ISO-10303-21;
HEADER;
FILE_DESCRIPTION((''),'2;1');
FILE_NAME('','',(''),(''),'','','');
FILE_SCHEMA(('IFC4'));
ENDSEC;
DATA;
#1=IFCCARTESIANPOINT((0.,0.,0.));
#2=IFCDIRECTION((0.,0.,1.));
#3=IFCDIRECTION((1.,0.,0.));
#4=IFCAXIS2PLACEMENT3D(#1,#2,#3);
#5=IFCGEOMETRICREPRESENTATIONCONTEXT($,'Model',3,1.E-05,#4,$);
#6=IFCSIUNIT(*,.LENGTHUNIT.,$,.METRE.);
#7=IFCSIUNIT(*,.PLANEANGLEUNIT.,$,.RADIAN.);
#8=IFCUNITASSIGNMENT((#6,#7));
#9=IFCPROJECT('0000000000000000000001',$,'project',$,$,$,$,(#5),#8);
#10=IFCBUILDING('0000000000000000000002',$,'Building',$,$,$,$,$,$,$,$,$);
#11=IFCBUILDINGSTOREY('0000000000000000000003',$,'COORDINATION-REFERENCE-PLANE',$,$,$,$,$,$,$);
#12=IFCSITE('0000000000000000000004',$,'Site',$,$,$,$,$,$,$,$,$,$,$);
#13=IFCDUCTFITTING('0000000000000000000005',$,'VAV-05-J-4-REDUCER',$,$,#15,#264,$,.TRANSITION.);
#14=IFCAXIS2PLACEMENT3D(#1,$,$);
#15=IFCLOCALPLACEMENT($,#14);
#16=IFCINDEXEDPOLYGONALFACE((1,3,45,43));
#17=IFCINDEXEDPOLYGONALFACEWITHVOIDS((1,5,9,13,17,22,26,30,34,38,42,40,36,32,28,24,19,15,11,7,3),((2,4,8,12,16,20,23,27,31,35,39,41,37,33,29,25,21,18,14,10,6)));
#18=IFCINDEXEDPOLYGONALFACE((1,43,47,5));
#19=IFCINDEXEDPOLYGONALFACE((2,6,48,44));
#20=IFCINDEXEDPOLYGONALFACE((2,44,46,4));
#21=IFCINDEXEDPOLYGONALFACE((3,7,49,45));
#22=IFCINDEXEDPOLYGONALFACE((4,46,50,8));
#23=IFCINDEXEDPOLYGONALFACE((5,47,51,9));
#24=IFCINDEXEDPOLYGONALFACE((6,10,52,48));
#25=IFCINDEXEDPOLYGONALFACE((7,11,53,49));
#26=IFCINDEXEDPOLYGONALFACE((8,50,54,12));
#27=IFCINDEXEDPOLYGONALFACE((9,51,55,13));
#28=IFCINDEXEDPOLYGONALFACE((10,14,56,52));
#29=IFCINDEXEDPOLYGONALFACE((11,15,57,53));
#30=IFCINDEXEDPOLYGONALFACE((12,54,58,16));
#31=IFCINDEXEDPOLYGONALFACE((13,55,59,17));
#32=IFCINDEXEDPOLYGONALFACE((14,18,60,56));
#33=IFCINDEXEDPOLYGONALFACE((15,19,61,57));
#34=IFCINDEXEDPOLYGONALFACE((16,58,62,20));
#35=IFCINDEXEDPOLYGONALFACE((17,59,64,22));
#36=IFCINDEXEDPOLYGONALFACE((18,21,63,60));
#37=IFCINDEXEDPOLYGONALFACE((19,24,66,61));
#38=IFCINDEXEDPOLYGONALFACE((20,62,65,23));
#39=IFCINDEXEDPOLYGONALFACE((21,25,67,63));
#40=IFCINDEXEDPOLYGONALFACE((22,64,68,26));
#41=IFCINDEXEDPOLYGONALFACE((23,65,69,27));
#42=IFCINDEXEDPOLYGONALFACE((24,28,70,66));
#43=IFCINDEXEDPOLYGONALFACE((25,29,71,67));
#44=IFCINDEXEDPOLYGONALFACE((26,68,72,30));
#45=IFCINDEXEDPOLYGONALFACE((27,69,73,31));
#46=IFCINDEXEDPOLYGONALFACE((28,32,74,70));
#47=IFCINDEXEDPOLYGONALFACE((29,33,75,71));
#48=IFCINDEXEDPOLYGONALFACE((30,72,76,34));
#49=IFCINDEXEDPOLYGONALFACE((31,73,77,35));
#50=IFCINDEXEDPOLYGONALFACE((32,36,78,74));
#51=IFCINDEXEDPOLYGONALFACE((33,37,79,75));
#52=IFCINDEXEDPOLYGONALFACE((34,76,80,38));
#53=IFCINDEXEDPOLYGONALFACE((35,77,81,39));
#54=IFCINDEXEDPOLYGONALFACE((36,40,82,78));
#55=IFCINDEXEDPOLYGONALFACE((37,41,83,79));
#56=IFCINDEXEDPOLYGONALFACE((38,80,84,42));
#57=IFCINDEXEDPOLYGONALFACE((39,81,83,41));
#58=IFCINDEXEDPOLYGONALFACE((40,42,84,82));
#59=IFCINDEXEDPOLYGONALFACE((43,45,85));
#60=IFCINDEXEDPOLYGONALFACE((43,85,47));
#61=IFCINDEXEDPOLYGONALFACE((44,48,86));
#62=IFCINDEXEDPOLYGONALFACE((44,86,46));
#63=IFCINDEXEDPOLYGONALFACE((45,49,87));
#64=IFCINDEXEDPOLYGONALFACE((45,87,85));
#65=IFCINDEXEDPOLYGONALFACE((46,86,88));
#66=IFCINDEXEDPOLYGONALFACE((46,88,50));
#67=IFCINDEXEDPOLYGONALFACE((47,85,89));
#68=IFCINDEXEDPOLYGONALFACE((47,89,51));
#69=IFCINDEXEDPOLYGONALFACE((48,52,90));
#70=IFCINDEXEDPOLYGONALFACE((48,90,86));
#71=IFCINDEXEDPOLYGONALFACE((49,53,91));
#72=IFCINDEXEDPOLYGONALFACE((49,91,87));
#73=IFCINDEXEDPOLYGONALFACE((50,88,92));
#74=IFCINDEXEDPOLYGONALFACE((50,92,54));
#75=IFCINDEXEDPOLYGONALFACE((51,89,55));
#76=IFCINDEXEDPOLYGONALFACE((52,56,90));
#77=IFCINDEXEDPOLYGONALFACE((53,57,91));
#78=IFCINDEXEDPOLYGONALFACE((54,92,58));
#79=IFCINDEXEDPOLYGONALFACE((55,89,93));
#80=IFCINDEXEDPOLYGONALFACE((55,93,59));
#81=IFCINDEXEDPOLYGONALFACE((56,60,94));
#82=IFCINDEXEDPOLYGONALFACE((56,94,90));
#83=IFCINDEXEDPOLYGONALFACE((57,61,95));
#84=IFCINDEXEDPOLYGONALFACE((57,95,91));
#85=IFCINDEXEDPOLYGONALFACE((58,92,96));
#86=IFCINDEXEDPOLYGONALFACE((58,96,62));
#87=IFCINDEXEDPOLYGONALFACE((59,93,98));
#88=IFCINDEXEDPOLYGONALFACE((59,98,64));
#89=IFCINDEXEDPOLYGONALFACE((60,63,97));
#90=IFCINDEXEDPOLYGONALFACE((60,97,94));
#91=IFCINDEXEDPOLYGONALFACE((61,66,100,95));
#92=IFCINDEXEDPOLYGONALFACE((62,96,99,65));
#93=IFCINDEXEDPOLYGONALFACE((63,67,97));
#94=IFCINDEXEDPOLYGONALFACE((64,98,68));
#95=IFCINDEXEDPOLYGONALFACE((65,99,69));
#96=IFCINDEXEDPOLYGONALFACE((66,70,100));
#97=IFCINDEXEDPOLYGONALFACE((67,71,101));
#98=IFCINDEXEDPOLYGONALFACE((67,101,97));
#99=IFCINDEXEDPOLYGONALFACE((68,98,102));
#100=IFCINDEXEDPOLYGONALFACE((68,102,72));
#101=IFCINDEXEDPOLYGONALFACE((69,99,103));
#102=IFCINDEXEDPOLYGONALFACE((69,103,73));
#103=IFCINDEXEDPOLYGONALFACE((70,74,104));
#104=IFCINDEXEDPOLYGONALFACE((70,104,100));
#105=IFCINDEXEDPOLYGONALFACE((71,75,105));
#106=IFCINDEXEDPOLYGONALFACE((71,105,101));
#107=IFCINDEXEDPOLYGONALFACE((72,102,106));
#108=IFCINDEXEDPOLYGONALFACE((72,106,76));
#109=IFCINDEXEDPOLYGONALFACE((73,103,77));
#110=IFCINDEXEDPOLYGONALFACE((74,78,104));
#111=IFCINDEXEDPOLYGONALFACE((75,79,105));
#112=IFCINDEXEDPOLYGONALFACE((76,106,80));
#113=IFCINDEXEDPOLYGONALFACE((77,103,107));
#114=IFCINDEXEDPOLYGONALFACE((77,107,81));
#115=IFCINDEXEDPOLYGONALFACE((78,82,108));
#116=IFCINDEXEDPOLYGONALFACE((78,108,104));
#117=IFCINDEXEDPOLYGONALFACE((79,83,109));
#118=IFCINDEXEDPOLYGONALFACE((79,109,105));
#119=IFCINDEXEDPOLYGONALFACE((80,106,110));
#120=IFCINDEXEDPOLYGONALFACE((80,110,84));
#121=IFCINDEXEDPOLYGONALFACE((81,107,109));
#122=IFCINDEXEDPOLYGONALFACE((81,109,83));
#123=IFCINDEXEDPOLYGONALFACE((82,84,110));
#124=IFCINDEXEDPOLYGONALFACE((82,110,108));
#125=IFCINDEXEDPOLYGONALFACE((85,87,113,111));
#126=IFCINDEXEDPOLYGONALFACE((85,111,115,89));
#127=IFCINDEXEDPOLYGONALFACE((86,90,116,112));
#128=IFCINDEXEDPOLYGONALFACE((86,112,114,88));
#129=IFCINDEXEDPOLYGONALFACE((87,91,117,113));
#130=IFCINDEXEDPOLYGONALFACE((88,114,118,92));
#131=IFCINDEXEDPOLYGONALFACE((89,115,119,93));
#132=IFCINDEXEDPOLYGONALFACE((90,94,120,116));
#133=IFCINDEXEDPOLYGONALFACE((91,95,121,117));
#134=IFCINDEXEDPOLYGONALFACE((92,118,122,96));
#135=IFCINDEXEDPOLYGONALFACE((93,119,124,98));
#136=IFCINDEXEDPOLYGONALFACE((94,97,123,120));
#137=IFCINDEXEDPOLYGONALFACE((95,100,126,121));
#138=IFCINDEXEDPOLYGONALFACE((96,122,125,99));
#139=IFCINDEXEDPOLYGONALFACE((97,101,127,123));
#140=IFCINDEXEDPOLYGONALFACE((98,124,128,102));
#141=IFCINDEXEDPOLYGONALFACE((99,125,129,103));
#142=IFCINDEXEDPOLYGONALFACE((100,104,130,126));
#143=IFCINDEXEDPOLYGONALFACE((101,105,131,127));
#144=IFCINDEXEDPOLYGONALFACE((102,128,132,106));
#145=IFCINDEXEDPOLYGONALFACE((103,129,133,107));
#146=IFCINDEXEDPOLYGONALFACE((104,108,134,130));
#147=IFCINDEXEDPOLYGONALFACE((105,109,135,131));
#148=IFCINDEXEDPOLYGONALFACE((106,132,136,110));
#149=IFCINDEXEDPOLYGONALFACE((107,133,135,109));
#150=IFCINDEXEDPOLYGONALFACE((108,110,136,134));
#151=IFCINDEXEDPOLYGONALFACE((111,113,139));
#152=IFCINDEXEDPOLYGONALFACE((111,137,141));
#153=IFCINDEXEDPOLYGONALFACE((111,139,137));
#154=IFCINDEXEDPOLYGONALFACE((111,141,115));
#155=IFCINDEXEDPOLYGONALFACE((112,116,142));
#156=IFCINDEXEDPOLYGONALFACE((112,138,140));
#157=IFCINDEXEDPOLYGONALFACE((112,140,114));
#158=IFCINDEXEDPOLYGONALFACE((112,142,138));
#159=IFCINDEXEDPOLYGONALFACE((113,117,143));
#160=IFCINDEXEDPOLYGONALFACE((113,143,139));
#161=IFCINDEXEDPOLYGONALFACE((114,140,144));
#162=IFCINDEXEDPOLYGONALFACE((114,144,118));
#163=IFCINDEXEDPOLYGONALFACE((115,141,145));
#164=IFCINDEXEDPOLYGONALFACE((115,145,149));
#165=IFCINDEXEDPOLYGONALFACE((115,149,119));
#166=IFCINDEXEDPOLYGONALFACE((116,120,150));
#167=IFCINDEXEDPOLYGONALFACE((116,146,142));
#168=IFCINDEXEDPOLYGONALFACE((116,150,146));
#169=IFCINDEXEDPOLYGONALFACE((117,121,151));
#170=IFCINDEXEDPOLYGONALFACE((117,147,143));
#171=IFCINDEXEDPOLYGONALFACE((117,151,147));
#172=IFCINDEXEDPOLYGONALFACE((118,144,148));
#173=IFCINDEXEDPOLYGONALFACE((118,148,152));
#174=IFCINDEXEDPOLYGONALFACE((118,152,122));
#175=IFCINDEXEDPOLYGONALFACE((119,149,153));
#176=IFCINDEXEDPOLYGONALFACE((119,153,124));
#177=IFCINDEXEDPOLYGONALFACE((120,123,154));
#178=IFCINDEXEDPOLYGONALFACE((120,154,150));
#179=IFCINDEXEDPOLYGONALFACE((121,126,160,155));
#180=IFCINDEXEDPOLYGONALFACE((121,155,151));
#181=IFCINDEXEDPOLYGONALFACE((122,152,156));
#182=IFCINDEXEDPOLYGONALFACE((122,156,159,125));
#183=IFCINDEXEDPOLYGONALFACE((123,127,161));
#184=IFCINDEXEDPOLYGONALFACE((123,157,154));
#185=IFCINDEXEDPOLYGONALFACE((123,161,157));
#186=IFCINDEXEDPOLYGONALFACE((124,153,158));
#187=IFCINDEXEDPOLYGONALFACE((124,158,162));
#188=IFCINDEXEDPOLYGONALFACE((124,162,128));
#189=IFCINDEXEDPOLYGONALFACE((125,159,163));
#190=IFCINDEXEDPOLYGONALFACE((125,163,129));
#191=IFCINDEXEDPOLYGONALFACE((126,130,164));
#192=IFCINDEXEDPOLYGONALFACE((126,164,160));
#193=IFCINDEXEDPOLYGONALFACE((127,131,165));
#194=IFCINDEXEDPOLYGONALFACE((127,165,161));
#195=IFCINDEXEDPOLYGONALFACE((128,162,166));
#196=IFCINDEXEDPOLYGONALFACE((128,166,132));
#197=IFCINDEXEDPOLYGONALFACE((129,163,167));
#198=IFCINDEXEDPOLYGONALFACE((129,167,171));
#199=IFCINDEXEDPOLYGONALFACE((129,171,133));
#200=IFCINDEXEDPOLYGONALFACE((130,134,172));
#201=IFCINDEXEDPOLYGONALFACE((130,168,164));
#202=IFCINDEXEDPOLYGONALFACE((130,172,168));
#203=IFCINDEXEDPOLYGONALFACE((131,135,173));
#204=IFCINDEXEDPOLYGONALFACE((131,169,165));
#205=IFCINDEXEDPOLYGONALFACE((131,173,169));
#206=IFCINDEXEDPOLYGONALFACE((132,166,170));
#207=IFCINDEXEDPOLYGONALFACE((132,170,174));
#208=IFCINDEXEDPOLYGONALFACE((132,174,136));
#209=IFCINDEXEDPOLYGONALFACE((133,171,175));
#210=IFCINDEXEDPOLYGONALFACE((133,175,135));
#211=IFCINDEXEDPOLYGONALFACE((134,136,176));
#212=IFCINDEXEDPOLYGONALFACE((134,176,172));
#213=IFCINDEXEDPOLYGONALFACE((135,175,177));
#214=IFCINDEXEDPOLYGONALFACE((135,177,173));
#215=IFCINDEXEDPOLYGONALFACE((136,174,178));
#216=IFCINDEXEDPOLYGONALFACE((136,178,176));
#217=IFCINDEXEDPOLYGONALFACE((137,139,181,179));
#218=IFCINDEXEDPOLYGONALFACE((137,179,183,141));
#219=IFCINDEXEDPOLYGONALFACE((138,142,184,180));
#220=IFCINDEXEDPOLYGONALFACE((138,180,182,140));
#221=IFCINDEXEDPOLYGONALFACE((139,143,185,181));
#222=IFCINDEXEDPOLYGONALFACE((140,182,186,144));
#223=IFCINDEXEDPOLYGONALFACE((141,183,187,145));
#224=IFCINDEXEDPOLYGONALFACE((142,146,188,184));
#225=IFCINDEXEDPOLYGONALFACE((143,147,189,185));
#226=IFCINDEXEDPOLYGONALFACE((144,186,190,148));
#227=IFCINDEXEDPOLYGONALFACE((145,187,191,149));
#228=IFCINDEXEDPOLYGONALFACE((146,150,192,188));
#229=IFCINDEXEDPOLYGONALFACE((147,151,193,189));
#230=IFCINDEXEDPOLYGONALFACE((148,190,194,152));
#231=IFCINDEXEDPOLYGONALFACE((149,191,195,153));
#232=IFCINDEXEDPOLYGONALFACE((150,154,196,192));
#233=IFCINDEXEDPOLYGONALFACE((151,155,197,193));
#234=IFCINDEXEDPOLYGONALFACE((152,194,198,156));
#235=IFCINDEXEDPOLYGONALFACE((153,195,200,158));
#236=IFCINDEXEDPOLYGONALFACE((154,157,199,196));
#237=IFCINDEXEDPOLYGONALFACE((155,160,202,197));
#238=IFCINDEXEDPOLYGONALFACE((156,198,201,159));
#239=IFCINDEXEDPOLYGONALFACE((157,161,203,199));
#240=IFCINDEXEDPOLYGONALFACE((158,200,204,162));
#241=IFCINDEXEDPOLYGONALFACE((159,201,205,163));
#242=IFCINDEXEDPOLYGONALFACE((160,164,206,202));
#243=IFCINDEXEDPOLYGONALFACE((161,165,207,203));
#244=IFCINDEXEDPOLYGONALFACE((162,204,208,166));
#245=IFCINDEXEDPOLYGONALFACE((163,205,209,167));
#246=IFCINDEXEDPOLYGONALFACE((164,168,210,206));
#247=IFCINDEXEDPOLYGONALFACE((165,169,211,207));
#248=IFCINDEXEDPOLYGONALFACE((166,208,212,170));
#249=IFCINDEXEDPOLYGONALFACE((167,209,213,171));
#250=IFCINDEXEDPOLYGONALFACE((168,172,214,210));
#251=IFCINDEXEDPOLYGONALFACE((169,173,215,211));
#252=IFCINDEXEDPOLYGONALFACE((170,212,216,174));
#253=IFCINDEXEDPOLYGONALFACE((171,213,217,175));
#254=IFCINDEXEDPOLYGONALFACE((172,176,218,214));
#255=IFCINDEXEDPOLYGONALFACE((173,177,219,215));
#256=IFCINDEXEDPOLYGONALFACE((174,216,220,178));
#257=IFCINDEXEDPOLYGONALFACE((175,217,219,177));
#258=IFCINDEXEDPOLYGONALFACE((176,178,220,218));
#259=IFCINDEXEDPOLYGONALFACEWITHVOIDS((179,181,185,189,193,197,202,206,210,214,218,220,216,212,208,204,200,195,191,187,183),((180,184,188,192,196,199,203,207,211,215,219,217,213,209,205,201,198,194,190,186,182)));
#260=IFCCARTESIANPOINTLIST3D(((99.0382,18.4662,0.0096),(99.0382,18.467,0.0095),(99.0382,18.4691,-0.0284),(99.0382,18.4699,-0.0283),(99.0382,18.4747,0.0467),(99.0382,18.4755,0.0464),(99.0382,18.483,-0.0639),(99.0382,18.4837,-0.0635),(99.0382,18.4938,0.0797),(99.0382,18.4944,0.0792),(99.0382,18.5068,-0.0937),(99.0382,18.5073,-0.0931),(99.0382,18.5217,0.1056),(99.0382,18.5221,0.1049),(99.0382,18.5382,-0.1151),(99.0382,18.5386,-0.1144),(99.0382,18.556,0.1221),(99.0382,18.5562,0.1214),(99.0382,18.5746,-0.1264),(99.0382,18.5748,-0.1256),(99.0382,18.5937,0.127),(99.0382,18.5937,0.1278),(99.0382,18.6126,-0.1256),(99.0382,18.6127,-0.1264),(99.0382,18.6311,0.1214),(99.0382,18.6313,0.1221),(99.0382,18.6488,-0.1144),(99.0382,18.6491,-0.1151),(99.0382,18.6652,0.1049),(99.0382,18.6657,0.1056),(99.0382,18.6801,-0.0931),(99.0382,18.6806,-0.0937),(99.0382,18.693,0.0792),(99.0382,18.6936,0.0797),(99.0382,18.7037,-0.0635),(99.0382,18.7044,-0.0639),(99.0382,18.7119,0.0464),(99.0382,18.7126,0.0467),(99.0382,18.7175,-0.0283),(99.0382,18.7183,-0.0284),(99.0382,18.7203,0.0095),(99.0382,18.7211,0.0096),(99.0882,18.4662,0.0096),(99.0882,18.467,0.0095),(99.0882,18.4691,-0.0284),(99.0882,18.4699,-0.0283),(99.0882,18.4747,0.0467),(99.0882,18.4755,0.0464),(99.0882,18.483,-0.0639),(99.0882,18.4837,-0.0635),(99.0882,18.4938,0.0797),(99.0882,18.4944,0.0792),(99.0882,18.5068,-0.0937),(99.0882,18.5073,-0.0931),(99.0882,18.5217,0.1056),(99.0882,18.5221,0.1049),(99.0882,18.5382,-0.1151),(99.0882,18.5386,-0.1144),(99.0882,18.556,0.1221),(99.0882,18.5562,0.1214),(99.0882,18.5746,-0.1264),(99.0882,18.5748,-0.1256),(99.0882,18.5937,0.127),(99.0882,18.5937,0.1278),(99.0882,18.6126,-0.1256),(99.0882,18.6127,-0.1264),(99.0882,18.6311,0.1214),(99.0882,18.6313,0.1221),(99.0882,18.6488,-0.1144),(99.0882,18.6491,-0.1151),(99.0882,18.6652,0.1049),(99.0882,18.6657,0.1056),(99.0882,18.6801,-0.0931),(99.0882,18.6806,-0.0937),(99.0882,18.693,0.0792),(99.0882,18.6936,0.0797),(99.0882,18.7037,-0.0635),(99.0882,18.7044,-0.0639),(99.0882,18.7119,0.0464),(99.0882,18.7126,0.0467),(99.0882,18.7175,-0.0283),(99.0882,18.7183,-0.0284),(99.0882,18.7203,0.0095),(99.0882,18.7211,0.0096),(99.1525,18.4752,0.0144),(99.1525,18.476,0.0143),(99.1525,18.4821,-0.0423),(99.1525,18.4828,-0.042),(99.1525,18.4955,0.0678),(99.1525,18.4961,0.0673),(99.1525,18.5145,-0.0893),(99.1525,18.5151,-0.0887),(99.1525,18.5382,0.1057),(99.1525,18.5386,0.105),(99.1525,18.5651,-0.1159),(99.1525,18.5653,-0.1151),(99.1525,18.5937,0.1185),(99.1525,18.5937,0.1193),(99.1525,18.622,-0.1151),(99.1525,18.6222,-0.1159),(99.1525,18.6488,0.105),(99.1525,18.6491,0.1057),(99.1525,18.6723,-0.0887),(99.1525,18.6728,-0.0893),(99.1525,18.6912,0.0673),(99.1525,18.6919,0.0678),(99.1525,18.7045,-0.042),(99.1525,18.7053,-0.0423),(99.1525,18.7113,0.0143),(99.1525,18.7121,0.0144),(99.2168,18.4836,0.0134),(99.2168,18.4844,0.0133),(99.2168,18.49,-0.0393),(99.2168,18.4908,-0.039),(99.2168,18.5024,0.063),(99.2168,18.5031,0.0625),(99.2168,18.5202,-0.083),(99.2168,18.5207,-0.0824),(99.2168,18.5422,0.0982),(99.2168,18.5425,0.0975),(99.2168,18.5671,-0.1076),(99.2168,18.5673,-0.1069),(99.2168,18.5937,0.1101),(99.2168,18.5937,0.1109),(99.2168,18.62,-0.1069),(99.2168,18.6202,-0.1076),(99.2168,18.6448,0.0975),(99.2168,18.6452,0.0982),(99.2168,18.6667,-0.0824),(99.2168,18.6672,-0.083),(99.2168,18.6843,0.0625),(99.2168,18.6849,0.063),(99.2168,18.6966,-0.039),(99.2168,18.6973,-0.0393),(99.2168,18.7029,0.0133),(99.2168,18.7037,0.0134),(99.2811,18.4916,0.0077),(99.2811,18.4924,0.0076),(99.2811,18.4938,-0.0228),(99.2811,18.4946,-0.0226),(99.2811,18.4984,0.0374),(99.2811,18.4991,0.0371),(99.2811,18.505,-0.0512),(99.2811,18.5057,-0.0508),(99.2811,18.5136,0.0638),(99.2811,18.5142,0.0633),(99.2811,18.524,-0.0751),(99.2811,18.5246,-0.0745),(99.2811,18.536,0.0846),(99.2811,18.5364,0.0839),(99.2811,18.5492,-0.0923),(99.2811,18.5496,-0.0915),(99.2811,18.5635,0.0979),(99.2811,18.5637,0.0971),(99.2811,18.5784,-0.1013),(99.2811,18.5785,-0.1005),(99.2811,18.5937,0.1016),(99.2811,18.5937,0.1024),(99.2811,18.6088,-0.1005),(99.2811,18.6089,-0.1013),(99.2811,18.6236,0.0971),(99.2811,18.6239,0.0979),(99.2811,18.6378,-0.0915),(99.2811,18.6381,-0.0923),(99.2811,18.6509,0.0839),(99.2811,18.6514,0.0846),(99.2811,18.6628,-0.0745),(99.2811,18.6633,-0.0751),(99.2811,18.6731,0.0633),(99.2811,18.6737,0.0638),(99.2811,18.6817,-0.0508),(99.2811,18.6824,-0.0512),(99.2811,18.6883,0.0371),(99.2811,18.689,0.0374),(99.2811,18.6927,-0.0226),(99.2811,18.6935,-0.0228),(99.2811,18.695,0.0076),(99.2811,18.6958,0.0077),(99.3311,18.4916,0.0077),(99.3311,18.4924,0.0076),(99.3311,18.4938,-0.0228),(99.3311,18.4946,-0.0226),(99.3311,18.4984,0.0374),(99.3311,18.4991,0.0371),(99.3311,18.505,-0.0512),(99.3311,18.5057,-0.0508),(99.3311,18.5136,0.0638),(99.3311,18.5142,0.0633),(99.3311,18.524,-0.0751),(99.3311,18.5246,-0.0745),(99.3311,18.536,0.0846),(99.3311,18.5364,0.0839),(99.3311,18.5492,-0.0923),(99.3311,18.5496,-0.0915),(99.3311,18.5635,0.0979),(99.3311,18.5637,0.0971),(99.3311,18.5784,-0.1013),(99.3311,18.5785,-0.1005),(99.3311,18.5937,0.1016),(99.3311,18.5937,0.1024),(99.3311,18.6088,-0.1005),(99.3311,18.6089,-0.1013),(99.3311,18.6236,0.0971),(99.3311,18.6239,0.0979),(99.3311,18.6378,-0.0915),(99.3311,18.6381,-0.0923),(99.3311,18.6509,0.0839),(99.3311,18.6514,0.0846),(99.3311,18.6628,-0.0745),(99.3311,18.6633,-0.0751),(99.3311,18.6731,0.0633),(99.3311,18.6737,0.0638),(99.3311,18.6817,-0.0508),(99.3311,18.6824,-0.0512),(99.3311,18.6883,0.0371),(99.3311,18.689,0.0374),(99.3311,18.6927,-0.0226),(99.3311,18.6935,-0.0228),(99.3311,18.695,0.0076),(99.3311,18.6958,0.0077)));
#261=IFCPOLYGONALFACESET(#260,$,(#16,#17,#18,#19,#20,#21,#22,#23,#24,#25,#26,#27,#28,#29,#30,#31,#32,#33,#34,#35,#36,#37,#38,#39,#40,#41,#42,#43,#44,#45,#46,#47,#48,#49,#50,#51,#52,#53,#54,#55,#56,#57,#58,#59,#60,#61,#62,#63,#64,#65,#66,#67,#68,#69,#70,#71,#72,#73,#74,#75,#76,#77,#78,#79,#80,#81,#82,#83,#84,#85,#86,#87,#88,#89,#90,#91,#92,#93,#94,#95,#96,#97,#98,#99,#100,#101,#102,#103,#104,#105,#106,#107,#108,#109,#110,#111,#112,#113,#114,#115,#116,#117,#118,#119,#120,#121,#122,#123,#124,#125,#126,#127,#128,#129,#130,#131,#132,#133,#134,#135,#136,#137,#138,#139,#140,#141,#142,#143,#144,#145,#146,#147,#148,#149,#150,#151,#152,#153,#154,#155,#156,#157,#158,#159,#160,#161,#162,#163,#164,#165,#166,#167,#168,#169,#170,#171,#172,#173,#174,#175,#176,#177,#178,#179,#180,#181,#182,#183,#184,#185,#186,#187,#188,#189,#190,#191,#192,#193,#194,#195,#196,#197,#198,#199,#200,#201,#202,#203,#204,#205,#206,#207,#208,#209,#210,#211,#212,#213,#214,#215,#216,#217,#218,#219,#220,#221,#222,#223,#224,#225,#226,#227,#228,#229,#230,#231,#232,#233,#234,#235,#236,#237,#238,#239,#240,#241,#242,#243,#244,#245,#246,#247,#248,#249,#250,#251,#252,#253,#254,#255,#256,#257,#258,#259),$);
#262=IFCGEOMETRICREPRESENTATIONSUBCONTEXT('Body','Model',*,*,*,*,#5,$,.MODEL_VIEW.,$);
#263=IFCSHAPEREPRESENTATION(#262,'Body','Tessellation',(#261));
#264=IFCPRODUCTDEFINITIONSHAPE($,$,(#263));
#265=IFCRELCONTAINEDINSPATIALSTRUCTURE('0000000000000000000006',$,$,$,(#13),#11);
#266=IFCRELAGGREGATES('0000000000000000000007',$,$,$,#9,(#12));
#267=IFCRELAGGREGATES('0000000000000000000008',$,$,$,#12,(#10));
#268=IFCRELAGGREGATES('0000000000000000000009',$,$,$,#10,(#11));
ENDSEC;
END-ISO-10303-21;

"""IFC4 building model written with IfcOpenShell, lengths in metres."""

from ifc_helpers import new_model, entity, si_unit, frame, origin_with_axes, place, context, subcontext, project, spatial, element, save


model = new_model("IFC4")

# Units and contexts
model_context = context("Model", 3, precision=1e-05, world=origin_with_axes())
body_context_1 = subcontext(model_context, "Body", "Model", "MODEL_VIEW")
ifc_project = project(units=[si_unit("LENGTHUNIT", "METRE"), si_unit("PLANEANGLEUNIT", "RADIAN")], contexts=[model_context])

# Site, building, storey
site = spatial("IfcSite", under=ifc_project, Name="Site")
building = spatial("IfcBuilding", under=site, Name="Building")
storey = spatial("IfcBuildingStorey", under=building, Name="COORDINATION-REFERENCE-PLANE")

# Duct fitting
for number, where, z_axis, x_axis, name in (
    (1, (99.0382, 18.5937, 0.0), (0.0, 1.0, 0.0), (0.0, 0.0, 1.0), "VAV-05-J-4-REDUCER"),
):
    element("IfcDuctFitting", number, at=place(None, frame(where, z_axis=z_axis, x_axis=x_axis)), inside=storey, Name=name, PredefinedType="TRANSITION", context=body_context_1, shape_type="SweptSolid", body=[
        entity("IfcRevolvedAreaSolid", entity("IfcArbitraryClosedProfileDef", "AREA", None, entity("IfcPolyline", [entity("IfcCartesianPoint", [0.1278, 0.0]), entity("IfcCartesianPoint", [0.1278, 0.05]), entity("IfcCartesianPoint", [0.1024, 0.2429]), entity("IfcCartesianPoint", [0.1024, 0.2929]), entity("IfcCartesianPoint", [0.1016, 0.2929]), entity("IfcCartesianPoint", [0.1016, 0.2429]), entity("IfcCartesianPoint", [0.127, 0.05]), entity("IfcCartesianPoint", [0.127, 0.0]), entity("IfcCartesianPoint", [0.1278, 0.0])])), entity("IfcAxis2Placement3D", entity("IfcCartesianPoint", [0.0, 0.0, 0.0])), entity("IfcAxis1Placement", entity("IfcCartesianPoint", [0.0, 0.0, 0.0]), entity("IfcDirection", [0.0, 1.0, 0.0])), 6.283185),
    ])

save(model, "model.ifc")
